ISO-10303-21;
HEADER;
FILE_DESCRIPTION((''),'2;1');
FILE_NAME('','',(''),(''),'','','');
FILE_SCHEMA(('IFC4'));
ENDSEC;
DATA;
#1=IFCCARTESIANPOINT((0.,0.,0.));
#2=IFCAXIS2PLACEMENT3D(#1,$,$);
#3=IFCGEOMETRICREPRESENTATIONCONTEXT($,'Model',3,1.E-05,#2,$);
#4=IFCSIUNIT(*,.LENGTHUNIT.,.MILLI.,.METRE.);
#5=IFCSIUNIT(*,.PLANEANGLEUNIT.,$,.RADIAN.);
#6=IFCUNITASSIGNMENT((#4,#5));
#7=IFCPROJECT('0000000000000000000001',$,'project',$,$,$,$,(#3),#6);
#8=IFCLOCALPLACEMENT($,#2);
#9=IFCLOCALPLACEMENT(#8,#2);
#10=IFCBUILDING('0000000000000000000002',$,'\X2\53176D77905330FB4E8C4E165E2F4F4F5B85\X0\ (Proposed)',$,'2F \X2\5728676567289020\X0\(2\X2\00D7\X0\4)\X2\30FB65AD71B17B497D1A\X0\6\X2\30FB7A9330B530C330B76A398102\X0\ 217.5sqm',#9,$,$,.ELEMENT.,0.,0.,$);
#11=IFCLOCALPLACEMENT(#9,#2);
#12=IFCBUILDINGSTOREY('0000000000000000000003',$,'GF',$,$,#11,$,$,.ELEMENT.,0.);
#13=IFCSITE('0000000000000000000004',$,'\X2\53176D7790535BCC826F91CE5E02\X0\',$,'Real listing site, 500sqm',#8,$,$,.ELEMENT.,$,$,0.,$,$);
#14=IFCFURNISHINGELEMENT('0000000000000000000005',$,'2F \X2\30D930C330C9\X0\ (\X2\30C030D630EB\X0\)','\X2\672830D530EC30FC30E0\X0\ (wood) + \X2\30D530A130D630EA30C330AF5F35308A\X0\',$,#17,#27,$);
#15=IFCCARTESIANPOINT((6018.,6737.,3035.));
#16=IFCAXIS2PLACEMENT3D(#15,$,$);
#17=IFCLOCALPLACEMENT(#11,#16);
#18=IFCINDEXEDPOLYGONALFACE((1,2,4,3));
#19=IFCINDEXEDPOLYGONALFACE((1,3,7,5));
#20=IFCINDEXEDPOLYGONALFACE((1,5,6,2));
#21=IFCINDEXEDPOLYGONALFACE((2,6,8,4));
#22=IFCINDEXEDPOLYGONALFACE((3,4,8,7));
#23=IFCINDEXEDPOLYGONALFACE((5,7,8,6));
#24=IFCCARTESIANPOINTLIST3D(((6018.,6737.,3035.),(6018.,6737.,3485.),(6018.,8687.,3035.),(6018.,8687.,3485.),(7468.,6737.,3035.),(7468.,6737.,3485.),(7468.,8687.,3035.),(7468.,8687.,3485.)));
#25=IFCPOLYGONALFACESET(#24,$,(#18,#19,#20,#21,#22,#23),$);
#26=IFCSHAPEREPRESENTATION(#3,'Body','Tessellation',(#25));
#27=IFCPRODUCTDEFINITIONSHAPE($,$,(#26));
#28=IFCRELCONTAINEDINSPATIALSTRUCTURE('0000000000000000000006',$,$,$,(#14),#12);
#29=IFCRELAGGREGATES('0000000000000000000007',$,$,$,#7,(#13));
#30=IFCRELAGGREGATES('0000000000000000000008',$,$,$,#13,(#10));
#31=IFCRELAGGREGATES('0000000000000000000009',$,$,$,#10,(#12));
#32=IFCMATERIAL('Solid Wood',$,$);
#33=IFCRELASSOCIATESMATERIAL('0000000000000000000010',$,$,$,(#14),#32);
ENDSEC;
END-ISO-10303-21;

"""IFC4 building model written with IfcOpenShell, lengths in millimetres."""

from ifc_helpers import new_model, si_unit, frame, frame_2d, origin, place, context, project, spatial, rectangle, extrude, material, element, save


model = new_model("IFC4")

# Units and contexts
model_context = context("Model", 3, precision=1e-05, world=origin())
ifc_project = project(units=[si_unit("LENGTHUNIT", "METRE", prefix="MILLI"), si_unit("PLANEANGLEUNIT", "RADIAN")], contexts=[model_context])

# Site, building, storey
site_placement = place(None, origin())
site = spatial("IfcSite", under=ifc_project, at=site_placement, Name="北海道富良野市", ObjectType="Real listing site, 500sqm", CompositionType="ELEMENT", RefElevation=0.0)
building_placement = place(site_placement, origin())
building = spatial("IfcBuilding", under=site, at=building_placement, Name="北海道・二世帯住宅 (Proposed)", ObjectType="2F 在来木造(2×4)・断熱等級6・窓サッシ樹脂 217.5sqm", CompositionType="ELEMENT", ElevationOfRefHeight=0.0, ElevationOfTerrain=0.0)
storey_placement = place(building_placement, origin())
storey = spatial("IfcBuildingStorey", under=building, at=storey_placement, Name="GF", CompositionType="ELEMENT", Elevation=0.0)

# Shared definitions
ifc_material_1 = material(Name="Solid Wood")

# Furnishing element
furnishing_1_placement = place(storey_placement, frame((6018.0, 6737.0, 3035.0)))
element("IfcFurnishingElement", 1, at=furnishing_1_placement, inside=storey, material=ifc_material_1, Name="2F ベッド (ダブル)", Description="木フレーム (wood) + ファブリック張り", context=model_context, shape_type="SweptSolid", body=[
    extrude(rectangle(XDim=1450.0, YDim=1950.0, at=frame_2d((725.0, 975.0))), frame((6018.0, 6737.0, 3035.0)), (0.0, 0.0, 1.0), 450.0),
])

save(model, "model.ifc")
